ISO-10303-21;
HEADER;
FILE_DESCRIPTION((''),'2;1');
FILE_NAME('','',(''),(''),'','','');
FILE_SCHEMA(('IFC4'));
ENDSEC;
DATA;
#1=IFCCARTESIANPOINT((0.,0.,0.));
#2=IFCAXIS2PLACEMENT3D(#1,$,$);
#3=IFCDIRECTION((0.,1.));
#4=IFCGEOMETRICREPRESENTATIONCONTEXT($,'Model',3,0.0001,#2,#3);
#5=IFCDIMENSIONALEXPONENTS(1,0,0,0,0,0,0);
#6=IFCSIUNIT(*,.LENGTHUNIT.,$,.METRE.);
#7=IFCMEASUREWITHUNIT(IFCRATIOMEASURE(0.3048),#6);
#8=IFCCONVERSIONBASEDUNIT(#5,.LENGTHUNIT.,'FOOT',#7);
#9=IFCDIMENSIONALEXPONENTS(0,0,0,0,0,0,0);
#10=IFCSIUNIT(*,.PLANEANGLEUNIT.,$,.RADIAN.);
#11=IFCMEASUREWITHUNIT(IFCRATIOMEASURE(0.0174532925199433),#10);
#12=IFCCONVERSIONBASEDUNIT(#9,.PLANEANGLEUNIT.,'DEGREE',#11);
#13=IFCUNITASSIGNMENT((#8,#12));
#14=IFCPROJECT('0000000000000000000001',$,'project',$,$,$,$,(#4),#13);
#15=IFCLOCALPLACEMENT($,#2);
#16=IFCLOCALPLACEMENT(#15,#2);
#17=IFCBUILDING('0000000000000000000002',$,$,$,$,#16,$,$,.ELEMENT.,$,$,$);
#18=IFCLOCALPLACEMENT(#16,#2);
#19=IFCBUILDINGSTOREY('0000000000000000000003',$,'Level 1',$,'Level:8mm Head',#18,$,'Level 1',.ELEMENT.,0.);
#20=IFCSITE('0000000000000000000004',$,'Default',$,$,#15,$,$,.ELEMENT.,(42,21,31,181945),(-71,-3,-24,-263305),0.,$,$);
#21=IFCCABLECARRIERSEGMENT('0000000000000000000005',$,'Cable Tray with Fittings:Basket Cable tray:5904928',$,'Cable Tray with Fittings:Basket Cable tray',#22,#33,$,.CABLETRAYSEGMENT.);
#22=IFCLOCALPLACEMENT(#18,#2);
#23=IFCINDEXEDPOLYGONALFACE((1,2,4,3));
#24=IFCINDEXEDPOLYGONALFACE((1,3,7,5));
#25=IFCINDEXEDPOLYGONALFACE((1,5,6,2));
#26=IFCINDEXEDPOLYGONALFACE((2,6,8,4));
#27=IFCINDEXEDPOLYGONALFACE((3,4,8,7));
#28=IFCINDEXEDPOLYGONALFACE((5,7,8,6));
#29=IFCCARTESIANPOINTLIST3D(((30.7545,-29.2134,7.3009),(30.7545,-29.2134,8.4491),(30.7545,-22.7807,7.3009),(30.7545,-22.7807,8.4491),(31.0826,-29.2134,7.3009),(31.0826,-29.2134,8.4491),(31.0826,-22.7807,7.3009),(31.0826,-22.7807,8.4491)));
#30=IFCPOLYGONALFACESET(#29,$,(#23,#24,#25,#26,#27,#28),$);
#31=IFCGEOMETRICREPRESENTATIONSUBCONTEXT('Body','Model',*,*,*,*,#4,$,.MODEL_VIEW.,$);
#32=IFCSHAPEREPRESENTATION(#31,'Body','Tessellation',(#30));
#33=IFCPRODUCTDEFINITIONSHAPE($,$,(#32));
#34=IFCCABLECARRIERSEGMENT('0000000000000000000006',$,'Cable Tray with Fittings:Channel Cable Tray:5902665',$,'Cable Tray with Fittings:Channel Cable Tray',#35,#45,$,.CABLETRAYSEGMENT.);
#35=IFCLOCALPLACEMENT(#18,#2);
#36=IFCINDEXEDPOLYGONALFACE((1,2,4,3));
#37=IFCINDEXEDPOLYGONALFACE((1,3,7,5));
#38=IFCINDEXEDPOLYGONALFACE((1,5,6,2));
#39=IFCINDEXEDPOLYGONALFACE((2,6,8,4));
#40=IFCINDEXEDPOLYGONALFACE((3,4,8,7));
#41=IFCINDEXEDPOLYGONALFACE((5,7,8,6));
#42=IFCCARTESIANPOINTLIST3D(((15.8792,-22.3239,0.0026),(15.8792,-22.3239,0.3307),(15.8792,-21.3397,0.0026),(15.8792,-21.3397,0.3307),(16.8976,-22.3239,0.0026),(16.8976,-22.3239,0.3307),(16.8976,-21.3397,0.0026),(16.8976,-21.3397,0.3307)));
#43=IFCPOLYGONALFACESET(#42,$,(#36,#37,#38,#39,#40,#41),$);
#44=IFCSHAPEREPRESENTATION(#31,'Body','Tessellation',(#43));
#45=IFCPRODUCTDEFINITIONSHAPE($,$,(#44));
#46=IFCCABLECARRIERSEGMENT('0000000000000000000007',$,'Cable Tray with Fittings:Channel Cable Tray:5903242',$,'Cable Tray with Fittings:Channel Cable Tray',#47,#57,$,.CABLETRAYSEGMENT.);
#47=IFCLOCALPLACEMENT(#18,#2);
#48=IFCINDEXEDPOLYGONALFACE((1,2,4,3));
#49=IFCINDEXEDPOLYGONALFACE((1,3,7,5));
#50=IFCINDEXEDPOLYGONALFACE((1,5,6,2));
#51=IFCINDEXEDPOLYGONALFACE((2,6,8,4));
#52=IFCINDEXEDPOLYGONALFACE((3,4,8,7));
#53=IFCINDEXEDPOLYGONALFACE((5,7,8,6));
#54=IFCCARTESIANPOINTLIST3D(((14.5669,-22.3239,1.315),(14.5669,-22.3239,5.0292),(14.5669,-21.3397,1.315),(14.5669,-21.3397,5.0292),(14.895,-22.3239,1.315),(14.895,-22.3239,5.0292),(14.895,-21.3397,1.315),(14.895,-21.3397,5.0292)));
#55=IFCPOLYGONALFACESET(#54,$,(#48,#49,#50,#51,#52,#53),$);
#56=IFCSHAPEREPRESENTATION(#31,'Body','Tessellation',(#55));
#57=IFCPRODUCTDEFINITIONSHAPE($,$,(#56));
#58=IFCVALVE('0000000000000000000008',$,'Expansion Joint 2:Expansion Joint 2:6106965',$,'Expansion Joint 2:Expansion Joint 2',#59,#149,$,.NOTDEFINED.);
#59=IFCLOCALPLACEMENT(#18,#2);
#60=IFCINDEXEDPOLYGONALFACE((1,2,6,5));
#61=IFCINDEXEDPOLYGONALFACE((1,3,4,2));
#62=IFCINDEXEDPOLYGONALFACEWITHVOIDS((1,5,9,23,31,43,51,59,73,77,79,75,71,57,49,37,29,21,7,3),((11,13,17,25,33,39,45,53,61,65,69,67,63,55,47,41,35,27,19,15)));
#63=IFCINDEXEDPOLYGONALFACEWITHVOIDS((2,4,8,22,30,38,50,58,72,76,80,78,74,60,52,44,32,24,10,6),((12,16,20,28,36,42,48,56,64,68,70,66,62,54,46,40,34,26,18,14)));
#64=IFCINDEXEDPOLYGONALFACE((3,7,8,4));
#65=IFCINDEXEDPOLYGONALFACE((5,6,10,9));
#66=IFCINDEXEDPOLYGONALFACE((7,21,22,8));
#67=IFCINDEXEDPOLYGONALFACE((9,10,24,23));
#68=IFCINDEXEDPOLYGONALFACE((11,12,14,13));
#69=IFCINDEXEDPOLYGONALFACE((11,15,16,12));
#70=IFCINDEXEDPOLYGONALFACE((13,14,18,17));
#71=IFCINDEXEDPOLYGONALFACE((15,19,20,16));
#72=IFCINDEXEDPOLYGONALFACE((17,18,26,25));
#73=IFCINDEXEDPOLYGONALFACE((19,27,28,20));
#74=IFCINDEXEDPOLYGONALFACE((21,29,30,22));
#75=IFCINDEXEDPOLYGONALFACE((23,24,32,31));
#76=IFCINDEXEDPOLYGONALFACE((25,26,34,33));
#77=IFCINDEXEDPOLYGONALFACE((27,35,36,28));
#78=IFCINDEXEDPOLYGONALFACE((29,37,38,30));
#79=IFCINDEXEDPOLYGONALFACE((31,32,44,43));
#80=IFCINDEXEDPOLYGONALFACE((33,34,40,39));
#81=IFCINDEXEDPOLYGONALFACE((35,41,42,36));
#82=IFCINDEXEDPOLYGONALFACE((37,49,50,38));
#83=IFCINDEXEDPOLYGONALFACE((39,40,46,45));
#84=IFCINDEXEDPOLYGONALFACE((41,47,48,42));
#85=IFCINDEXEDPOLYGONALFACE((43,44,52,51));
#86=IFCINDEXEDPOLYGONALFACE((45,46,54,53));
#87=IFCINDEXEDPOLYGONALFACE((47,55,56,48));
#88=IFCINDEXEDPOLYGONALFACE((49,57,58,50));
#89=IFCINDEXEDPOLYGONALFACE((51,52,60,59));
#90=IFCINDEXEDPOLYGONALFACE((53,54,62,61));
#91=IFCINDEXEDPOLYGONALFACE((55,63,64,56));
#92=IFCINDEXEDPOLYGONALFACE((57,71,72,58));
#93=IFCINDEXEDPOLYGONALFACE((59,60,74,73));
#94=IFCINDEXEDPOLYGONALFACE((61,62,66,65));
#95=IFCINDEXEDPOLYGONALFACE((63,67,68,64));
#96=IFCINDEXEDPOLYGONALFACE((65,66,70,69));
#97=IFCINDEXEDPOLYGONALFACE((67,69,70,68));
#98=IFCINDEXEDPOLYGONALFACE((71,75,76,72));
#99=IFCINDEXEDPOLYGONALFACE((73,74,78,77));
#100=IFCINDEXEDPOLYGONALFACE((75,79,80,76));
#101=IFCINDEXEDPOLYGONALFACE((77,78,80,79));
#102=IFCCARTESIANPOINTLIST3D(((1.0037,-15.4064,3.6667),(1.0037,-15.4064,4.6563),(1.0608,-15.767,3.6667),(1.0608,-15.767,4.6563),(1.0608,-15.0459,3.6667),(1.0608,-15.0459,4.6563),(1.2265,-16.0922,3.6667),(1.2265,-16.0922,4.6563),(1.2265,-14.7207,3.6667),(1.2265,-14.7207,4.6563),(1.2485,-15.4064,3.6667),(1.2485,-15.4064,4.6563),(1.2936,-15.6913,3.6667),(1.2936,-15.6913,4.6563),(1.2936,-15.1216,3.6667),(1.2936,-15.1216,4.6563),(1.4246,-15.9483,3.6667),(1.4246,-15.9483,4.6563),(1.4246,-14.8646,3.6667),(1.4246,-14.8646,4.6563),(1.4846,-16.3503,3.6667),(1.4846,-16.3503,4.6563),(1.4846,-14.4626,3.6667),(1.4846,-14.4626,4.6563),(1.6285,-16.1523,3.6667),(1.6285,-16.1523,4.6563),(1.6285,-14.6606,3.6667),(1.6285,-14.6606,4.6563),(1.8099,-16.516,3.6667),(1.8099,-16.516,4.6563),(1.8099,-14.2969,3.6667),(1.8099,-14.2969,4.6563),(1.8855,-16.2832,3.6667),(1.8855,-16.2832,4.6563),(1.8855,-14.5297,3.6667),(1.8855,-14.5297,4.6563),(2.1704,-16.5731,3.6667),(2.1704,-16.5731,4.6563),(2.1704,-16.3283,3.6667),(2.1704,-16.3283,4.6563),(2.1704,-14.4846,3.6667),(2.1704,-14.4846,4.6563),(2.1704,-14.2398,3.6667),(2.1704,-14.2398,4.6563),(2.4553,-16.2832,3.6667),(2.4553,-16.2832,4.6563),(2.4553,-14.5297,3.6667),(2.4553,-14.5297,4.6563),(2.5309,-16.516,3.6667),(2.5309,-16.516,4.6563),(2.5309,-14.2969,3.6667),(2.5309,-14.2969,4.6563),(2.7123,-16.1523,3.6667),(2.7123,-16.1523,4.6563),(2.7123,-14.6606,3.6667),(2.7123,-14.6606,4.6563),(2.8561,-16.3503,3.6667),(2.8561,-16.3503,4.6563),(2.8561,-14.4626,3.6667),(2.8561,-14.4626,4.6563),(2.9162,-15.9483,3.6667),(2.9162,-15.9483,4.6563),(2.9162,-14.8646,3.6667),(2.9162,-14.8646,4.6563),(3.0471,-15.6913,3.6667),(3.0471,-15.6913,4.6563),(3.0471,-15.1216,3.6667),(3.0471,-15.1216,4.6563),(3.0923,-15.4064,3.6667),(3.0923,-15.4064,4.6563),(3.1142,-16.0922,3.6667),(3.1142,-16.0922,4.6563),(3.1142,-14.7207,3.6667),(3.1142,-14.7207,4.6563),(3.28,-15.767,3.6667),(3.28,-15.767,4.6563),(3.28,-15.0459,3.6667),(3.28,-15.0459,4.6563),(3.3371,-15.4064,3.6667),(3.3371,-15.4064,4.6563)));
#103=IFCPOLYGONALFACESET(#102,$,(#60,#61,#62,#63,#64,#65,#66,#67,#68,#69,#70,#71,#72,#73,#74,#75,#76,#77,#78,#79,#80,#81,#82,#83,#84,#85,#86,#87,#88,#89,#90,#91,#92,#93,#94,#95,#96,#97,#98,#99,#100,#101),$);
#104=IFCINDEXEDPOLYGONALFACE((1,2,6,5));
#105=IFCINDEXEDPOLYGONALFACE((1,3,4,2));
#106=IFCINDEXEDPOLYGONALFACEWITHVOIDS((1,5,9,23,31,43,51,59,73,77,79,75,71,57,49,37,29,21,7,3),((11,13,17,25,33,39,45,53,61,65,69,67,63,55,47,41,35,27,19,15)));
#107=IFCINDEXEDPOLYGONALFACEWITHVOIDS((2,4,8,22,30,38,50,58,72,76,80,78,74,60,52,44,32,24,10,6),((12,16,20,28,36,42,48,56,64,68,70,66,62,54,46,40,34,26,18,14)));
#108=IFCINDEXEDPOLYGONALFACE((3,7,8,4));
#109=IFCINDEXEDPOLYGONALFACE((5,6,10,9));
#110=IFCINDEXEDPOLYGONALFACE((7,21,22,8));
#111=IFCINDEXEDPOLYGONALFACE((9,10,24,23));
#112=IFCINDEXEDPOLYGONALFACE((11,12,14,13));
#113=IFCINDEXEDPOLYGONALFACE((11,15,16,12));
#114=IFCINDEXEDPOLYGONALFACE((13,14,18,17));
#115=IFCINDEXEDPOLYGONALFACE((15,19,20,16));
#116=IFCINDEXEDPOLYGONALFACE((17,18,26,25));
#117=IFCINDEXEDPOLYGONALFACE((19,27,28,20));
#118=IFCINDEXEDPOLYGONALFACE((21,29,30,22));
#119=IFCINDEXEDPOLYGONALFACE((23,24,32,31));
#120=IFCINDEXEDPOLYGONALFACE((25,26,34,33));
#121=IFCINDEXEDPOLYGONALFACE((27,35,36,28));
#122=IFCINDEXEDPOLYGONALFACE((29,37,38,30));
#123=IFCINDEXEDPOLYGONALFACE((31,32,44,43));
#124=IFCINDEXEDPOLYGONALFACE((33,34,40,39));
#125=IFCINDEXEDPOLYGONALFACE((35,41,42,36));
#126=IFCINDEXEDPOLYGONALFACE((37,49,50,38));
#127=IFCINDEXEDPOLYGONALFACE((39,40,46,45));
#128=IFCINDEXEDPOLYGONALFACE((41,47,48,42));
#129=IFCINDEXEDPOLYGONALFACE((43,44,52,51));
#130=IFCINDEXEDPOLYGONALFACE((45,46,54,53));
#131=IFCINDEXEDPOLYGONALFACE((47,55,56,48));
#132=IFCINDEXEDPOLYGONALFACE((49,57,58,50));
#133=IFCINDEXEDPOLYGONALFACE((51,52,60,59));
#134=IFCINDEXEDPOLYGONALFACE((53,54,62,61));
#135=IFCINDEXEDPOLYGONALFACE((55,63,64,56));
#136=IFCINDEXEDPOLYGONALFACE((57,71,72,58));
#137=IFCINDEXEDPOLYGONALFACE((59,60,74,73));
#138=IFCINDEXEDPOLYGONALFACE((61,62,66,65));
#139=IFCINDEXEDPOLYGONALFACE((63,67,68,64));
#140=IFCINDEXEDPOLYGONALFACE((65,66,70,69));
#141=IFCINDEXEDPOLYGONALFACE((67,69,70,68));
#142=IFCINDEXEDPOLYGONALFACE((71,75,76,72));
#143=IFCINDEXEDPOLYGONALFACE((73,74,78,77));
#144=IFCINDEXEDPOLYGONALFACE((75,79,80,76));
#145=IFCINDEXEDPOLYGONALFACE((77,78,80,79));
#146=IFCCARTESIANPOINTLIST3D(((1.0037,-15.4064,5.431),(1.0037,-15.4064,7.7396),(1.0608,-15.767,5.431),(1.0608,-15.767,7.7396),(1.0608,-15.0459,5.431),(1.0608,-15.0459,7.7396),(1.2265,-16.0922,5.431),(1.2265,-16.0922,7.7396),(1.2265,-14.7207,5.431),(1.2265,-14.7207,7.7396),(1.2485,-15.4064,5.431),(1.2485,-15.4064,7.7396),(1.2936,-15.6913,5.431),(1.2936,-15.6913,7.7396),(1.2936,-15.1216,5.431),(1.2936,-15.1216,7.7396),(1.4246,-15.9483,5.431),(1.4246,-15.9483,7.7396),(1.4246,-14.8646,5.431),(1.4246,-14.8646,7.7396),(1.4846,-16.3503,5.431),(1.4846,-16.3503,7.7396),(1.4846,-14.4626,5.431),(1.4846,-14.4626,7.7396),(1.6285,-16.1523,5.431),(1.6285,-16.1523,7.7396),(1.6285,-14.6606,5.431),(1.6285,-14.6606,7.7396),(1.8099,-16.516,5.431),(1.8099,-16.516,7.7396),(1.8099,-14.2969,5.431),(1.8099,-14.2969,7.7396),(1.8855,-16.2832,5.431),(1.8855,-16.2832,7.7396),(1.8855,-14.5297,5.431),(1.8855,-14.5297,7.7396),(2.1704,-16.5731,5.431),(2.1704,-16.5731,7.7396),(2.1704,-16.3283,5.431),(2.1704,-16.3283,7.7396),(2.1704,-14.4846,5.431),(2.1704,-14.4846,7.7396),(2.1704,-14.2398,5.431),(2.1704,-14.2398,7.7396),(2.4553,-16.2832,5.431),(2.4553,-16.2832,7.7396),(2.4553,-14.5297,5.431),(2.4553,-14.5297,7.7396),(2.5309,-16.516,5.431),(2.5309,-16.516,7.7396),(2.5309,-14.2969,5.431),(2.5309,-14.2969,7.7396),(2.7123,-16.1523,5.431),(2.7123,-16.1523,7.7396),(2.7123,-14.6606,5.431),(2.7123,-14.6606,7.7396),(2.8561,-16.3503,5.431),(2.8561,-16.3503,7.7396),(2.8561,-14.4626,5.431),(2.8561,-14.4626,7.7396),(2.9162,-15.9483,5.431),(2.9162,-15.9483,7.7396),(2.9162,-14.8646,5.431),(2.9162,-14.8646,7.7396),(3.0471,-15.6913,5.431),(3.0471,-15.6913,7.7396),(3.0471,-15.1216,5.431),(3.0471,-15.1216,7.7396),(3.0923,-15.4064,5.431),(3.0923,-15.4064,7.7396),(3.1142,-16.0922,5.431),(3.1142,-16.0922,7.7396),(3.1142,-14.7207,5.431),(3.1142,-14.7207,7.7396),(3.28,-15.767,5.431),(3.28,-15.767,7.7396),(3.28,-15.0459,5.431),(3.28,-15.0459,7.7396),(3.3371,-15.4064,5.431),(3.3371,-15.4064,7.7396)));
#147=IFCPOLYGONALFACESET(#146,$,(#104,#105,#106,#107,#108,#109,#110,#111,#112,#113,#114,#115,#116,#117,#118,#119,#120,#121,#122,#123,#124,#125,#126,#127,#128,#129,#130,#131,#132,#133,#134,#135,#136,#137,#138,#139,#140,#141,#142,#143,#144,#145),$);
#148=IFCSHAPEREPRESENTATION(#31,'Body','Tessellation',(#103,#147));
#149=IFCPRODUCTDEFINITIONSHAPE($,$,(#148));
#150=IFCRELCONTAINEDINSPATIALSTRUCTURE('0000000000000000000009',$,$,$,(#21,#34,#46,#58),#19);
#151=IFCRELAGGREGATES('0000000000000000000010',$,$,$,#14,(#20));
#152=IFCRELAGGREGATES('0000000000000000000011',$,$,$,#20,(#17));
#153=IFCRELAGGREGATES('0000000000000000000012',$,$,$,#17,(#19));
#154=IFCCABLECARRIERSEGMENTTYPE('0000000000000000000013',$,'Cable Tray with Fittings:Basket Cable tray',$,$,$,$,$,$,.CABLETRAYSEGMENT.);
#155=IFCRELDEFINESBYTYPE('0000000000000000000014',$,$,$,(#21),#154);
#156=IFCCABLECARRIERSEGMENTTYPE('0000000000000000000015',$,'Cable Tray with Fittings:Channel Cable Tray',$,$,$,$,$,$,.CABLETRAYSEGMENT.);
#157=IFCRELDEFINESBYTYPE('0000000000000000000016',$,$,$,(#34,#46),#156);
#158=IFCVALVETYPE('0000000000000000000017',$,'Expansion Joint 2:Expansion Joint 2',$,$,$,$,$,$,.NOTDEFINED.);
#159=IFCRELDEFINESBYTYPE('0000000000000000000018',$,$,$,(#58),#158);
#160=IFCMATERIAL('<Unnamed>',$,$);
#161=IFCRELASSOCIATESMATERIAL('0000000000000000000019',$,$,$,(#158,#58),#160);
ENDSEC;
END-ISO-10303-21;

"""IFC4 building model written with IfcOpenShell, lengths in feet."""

from ifc_helpers import new_model, entity, si_unit, converted_unit, direction, frame, origin, place, context, subcontext, project, spatial, indexed_curve, outline, extrude, source, transform, mapped, material, type_object, type_shapes, element, save


model = new_model("IFC4")

# Units and contexts
model_context = context("Model", 3, precision=0.0001, world=origin(), true_north=direction((0.0, 1.0)))
body_context = subcontext(model_context, "Body", "Model", "MODEL_VIEW")
ifc_project = project(units=[converted_unit("LENGTHUNIT", "FOOT", entity("IfcRatioMeasure", 0.3048), si_unit("LENGTHUNIT", "METRE"), dimensions=[1, 0, 0, 0, 0, 0, 0]), converted_unit("PLANEANGLEUNIT", "DEGREE", entity("IfcRatioMeasure", 0.0174532925199433), si_unit("PLANEANGLEUNIT", "RADIAN"), dimensions=[0, 0, 0, 0, 0, 0, 0])], contexts=[model_context])

# Site, building, storey
site_placement = place(None, origin())
site = spatial("IfcSite", under=ifc_project, at=site_placement, Name="Default", CompositionType="ELEMENT", RefLatitude=(42, 21, 31, 181945), RefLongitude=(-71, -3, -24, -263305), RefElevation=0.0)
building_placement = place(site_placement, origin())
building = spatial("IfcBuilding", under=site, at=building_placement, CompositionType="ELEMENT")
storey_placement = place(building_placement, origin())
storey = spatial("IfcBuildingStorey", under=building, at=storey_placement, Name="Level 1", ObjectType="Level:8mm Head", LongName="Level 1", CompositionType="ELEMENT", Elevation=0.0)

# Cable carrier segments
cable_carrier_segment_type_1 = type_object("IfcCableCarrierSegmentType", Name="Cable Tray with Fittings:Basket Cable tray", PredefinedType="CABLETRAYSEGMENT")
cable_carrier_segment_1_placement = place(storey_placement, origin())
element("IfcCableCarrierSegment", 1, at=cable_carrier_segment_1_placement, inside=storey, type_object=cable_carrier_segment_type_1, Name="Cable Tray with Fittings:Basket Cable tray:5904928", ObjectType="Cable Tray with Fittings:Basket Cable tray", PredefinedType="CABLETRAYSEGMENT", context=body_context, shape_type="SweptSolid", body=[
    extrude(outline(indexed_curve([(-3.2164, -0.164), (3.2164, -0.164), (3.2164, 0.164), (-3.2164, 0.164), (-3.2164, -0.164)], self_intersect=False)), frame((30.9186, -25.997, 7.3009), z_axis=(0.0, 0.0, 1.0), x_axis=(0.0, -1.0, 0.0)), (0.0, 0.0, 1.0), 1.1483),
])
cable_carrier_segment_type_2 = type_object("IfcCableCarrierSegmentType", Name="Cable Tray with Fittings:Channel Cable Tray", PredefinedType="CABLETRAYSEGMENT")
cable_carrier_segment_2_placement = place(storey_placement, origin())
element("IfcCableCarrierSegment", 2, at=cable_carrier_segment_2_placement, inside=storey, type_object=cable_carrier_segment_type_2, Name="Cable Tray with Fittings:Channel Cable Tray:5902665", ObjectType="Cable Tray with Fittings:Channel Cable Tray", PredefinedType="CABLETRAYSEGMENT", context=body_context, shape_type="SweptSolid", body=[
    extrude(outline(indexed_curve([(-0.5092, -0.4921), (0.5092, -0.4921), (0.5092, 0.4921), (-0.5092, 0.4921), (-0.5092, -0.4921)], self_intersect=False)), frame((16.3884, -21.8318, 0.0026)), (0.0, 0.0, 1.0), 0.3281),
])
cable_carrier_segment_3_placement = place(storey_placement, origin())
element("IfcCableCarrierSegment", 3, at=cable_carrier_segment_3_placement, inside=storey, type_object=cable_carrier_segment_type_2, Name="Cable Tray with Fittings:Channel Cable Tray:5903242", ObjectType="Cable Tray with Fittings:Channel Cable Tray", PredefinedType="CABLETRAYSEGMENT", context=body_context, shape_type="SweptSolid", body=[
    extrude(outline(indexed_curve([(-0.4921, -0.164), (0.4921, -0.164), (0.4921, 0.164), (-0.4921, 0.164), (-0.4921, -0.164)], self_intersect=False)), frame((14.7309, -21.8318, 1.315), z_axis=(0.0, 0.0, 1.0), x_axis=(0.0, -1.0, 0.0)), (0.0, 0.0, 1.0), 3.7142),
])

# Valve
ifc_material_1 = material(Name="<Unnamed>")
valve_type_1 = type_object("IfcValveType", Name="Expansion Joint 2:Expansion Joint 2", PredefinedType="NOTDEFINED", material=ifc_material_1)
shared_shape_1 = source(origin(), body_context, "Body", "SweptSolid", [
    extrude(outline(indexed_curve([(1.1667, 0.0), (1.1096, 0.3605), (0.9439, 0.6857), (0.6857, 0.9439), (0.3605, 1.1096), (0.0, 1.1667), (-0.3605, 1.1096), (-0.6857, 0.9439), (-0.9439, 0.6857), (-1.1096, 0.3605), (-1.1667, 0.0), (-1.1096, -0.3605), (-0.9439, -0.6857), (-0.6857, -0.9439), (-0.3605, -1.1096), (0.0, -1.1667), (0.3605, -1.1096), (0.6857, -0.9439), (0.9439, -0.6857), (1.1096, -0.3605), (1.1667, 0.0)], self_intersect=False), holes=[indexed_curve([(0.0, 0.9219), (0.2849, 0.8768), (0.5419, 0.7458), (0.7458, 0.5419), (0.8768, 0.2849), (0.9219, 0.0), (0.8768, -0.2849), (0.7458, -0.5419), (0.5419, -0.7458), (0.2849, -0.8768), (0.0, -0.9219), (-0.2849, -0.8768), (-0.5419, -0.7458), (-0.7458, -0.5419), (-0.8768, -0.2849), (-0.9219, 0.0), (-0.8768, 0.2849), (-0.7458, 0.5419), (-0.5419, 0.7458), (-0.2849, 0.8768), (0.0, 0.9219)], self_intersect=False)]), origin(), (0.0, 0.0, 1.0), 0.9896),
    extrude(outline(indexed_curve([(1.1667, 0.0), (1.1096, 0.3605), (0.9439, 0.6857), (0.6857, 0.9439), (0.3605, 1.1096), (0.0, 1.1667), (-0.3605, 1.1096), (-0.6857, 0.9439), (-0.9439, 0.6857), (-1.1096, 0.3605), (-1.1667, 0.0), (-1.1096, -0.3605), (-0.9439, -0.6857), (-0.6857, -0.9439), (-0.3605, -1.1096), (0.0, -1.1667), (0.3605, -1.1096), (0.6857, -0.9439), (0.9439, -0.6857), (1.1096, -0.3605), (1.1667, 0.0)], self_intersect=False), holes=[indexed_curve([(0.0, 0.9219), (0.2849, 0.8768), (0.5419, 0.7458), (0.7458, 0.5419), (0.8768, 0.2849), (0.9219, 0.0), (0.8768, -0.2849), (0.7458, -0.5419), (0.5419, -0.7458), (0.2849, -0.8768), (0.0, -0.9219), (-0.2849, -0.8768), (-0.5419, -0.7458), (-0.7458, -0.5419), (-0.8768, -0.2849), (-0.9219, 0.0), (-0.8768, 0.2849), (-0.7458, 0.5419), (-0.5419, 0.7458), (-0.2849, 0.8768), (0.0, 0.9219)], self_intersect=False)]), frame((0.0, 0.0, 1.7644)), (0.0, 0.0, 1.0), 2.3086),
])
type_shapes(valve_type_1, [shared_shape_1])
valve_1_placement = place(storey_placement, frame((2.1704, -15.4064, 3.6667)))
element("IfcValve", 4, at=valve_1_placement, inside=storey, type_object=valve_type_1, material=ifc_material_1, Name="Expansion Joint 2:Expansion Joint 2:6106965", ObjectType="Expansion Joint 2:Expansion Joint 2", PredefinedType="NOTDEFINED", context=body_context, shape_type="MappedRepresentation", body=[
    mapped(shared_shape_1, transform((0.0, 0.0, 0.0), scale=1.0)),
])

save(model, "model.ifc")
